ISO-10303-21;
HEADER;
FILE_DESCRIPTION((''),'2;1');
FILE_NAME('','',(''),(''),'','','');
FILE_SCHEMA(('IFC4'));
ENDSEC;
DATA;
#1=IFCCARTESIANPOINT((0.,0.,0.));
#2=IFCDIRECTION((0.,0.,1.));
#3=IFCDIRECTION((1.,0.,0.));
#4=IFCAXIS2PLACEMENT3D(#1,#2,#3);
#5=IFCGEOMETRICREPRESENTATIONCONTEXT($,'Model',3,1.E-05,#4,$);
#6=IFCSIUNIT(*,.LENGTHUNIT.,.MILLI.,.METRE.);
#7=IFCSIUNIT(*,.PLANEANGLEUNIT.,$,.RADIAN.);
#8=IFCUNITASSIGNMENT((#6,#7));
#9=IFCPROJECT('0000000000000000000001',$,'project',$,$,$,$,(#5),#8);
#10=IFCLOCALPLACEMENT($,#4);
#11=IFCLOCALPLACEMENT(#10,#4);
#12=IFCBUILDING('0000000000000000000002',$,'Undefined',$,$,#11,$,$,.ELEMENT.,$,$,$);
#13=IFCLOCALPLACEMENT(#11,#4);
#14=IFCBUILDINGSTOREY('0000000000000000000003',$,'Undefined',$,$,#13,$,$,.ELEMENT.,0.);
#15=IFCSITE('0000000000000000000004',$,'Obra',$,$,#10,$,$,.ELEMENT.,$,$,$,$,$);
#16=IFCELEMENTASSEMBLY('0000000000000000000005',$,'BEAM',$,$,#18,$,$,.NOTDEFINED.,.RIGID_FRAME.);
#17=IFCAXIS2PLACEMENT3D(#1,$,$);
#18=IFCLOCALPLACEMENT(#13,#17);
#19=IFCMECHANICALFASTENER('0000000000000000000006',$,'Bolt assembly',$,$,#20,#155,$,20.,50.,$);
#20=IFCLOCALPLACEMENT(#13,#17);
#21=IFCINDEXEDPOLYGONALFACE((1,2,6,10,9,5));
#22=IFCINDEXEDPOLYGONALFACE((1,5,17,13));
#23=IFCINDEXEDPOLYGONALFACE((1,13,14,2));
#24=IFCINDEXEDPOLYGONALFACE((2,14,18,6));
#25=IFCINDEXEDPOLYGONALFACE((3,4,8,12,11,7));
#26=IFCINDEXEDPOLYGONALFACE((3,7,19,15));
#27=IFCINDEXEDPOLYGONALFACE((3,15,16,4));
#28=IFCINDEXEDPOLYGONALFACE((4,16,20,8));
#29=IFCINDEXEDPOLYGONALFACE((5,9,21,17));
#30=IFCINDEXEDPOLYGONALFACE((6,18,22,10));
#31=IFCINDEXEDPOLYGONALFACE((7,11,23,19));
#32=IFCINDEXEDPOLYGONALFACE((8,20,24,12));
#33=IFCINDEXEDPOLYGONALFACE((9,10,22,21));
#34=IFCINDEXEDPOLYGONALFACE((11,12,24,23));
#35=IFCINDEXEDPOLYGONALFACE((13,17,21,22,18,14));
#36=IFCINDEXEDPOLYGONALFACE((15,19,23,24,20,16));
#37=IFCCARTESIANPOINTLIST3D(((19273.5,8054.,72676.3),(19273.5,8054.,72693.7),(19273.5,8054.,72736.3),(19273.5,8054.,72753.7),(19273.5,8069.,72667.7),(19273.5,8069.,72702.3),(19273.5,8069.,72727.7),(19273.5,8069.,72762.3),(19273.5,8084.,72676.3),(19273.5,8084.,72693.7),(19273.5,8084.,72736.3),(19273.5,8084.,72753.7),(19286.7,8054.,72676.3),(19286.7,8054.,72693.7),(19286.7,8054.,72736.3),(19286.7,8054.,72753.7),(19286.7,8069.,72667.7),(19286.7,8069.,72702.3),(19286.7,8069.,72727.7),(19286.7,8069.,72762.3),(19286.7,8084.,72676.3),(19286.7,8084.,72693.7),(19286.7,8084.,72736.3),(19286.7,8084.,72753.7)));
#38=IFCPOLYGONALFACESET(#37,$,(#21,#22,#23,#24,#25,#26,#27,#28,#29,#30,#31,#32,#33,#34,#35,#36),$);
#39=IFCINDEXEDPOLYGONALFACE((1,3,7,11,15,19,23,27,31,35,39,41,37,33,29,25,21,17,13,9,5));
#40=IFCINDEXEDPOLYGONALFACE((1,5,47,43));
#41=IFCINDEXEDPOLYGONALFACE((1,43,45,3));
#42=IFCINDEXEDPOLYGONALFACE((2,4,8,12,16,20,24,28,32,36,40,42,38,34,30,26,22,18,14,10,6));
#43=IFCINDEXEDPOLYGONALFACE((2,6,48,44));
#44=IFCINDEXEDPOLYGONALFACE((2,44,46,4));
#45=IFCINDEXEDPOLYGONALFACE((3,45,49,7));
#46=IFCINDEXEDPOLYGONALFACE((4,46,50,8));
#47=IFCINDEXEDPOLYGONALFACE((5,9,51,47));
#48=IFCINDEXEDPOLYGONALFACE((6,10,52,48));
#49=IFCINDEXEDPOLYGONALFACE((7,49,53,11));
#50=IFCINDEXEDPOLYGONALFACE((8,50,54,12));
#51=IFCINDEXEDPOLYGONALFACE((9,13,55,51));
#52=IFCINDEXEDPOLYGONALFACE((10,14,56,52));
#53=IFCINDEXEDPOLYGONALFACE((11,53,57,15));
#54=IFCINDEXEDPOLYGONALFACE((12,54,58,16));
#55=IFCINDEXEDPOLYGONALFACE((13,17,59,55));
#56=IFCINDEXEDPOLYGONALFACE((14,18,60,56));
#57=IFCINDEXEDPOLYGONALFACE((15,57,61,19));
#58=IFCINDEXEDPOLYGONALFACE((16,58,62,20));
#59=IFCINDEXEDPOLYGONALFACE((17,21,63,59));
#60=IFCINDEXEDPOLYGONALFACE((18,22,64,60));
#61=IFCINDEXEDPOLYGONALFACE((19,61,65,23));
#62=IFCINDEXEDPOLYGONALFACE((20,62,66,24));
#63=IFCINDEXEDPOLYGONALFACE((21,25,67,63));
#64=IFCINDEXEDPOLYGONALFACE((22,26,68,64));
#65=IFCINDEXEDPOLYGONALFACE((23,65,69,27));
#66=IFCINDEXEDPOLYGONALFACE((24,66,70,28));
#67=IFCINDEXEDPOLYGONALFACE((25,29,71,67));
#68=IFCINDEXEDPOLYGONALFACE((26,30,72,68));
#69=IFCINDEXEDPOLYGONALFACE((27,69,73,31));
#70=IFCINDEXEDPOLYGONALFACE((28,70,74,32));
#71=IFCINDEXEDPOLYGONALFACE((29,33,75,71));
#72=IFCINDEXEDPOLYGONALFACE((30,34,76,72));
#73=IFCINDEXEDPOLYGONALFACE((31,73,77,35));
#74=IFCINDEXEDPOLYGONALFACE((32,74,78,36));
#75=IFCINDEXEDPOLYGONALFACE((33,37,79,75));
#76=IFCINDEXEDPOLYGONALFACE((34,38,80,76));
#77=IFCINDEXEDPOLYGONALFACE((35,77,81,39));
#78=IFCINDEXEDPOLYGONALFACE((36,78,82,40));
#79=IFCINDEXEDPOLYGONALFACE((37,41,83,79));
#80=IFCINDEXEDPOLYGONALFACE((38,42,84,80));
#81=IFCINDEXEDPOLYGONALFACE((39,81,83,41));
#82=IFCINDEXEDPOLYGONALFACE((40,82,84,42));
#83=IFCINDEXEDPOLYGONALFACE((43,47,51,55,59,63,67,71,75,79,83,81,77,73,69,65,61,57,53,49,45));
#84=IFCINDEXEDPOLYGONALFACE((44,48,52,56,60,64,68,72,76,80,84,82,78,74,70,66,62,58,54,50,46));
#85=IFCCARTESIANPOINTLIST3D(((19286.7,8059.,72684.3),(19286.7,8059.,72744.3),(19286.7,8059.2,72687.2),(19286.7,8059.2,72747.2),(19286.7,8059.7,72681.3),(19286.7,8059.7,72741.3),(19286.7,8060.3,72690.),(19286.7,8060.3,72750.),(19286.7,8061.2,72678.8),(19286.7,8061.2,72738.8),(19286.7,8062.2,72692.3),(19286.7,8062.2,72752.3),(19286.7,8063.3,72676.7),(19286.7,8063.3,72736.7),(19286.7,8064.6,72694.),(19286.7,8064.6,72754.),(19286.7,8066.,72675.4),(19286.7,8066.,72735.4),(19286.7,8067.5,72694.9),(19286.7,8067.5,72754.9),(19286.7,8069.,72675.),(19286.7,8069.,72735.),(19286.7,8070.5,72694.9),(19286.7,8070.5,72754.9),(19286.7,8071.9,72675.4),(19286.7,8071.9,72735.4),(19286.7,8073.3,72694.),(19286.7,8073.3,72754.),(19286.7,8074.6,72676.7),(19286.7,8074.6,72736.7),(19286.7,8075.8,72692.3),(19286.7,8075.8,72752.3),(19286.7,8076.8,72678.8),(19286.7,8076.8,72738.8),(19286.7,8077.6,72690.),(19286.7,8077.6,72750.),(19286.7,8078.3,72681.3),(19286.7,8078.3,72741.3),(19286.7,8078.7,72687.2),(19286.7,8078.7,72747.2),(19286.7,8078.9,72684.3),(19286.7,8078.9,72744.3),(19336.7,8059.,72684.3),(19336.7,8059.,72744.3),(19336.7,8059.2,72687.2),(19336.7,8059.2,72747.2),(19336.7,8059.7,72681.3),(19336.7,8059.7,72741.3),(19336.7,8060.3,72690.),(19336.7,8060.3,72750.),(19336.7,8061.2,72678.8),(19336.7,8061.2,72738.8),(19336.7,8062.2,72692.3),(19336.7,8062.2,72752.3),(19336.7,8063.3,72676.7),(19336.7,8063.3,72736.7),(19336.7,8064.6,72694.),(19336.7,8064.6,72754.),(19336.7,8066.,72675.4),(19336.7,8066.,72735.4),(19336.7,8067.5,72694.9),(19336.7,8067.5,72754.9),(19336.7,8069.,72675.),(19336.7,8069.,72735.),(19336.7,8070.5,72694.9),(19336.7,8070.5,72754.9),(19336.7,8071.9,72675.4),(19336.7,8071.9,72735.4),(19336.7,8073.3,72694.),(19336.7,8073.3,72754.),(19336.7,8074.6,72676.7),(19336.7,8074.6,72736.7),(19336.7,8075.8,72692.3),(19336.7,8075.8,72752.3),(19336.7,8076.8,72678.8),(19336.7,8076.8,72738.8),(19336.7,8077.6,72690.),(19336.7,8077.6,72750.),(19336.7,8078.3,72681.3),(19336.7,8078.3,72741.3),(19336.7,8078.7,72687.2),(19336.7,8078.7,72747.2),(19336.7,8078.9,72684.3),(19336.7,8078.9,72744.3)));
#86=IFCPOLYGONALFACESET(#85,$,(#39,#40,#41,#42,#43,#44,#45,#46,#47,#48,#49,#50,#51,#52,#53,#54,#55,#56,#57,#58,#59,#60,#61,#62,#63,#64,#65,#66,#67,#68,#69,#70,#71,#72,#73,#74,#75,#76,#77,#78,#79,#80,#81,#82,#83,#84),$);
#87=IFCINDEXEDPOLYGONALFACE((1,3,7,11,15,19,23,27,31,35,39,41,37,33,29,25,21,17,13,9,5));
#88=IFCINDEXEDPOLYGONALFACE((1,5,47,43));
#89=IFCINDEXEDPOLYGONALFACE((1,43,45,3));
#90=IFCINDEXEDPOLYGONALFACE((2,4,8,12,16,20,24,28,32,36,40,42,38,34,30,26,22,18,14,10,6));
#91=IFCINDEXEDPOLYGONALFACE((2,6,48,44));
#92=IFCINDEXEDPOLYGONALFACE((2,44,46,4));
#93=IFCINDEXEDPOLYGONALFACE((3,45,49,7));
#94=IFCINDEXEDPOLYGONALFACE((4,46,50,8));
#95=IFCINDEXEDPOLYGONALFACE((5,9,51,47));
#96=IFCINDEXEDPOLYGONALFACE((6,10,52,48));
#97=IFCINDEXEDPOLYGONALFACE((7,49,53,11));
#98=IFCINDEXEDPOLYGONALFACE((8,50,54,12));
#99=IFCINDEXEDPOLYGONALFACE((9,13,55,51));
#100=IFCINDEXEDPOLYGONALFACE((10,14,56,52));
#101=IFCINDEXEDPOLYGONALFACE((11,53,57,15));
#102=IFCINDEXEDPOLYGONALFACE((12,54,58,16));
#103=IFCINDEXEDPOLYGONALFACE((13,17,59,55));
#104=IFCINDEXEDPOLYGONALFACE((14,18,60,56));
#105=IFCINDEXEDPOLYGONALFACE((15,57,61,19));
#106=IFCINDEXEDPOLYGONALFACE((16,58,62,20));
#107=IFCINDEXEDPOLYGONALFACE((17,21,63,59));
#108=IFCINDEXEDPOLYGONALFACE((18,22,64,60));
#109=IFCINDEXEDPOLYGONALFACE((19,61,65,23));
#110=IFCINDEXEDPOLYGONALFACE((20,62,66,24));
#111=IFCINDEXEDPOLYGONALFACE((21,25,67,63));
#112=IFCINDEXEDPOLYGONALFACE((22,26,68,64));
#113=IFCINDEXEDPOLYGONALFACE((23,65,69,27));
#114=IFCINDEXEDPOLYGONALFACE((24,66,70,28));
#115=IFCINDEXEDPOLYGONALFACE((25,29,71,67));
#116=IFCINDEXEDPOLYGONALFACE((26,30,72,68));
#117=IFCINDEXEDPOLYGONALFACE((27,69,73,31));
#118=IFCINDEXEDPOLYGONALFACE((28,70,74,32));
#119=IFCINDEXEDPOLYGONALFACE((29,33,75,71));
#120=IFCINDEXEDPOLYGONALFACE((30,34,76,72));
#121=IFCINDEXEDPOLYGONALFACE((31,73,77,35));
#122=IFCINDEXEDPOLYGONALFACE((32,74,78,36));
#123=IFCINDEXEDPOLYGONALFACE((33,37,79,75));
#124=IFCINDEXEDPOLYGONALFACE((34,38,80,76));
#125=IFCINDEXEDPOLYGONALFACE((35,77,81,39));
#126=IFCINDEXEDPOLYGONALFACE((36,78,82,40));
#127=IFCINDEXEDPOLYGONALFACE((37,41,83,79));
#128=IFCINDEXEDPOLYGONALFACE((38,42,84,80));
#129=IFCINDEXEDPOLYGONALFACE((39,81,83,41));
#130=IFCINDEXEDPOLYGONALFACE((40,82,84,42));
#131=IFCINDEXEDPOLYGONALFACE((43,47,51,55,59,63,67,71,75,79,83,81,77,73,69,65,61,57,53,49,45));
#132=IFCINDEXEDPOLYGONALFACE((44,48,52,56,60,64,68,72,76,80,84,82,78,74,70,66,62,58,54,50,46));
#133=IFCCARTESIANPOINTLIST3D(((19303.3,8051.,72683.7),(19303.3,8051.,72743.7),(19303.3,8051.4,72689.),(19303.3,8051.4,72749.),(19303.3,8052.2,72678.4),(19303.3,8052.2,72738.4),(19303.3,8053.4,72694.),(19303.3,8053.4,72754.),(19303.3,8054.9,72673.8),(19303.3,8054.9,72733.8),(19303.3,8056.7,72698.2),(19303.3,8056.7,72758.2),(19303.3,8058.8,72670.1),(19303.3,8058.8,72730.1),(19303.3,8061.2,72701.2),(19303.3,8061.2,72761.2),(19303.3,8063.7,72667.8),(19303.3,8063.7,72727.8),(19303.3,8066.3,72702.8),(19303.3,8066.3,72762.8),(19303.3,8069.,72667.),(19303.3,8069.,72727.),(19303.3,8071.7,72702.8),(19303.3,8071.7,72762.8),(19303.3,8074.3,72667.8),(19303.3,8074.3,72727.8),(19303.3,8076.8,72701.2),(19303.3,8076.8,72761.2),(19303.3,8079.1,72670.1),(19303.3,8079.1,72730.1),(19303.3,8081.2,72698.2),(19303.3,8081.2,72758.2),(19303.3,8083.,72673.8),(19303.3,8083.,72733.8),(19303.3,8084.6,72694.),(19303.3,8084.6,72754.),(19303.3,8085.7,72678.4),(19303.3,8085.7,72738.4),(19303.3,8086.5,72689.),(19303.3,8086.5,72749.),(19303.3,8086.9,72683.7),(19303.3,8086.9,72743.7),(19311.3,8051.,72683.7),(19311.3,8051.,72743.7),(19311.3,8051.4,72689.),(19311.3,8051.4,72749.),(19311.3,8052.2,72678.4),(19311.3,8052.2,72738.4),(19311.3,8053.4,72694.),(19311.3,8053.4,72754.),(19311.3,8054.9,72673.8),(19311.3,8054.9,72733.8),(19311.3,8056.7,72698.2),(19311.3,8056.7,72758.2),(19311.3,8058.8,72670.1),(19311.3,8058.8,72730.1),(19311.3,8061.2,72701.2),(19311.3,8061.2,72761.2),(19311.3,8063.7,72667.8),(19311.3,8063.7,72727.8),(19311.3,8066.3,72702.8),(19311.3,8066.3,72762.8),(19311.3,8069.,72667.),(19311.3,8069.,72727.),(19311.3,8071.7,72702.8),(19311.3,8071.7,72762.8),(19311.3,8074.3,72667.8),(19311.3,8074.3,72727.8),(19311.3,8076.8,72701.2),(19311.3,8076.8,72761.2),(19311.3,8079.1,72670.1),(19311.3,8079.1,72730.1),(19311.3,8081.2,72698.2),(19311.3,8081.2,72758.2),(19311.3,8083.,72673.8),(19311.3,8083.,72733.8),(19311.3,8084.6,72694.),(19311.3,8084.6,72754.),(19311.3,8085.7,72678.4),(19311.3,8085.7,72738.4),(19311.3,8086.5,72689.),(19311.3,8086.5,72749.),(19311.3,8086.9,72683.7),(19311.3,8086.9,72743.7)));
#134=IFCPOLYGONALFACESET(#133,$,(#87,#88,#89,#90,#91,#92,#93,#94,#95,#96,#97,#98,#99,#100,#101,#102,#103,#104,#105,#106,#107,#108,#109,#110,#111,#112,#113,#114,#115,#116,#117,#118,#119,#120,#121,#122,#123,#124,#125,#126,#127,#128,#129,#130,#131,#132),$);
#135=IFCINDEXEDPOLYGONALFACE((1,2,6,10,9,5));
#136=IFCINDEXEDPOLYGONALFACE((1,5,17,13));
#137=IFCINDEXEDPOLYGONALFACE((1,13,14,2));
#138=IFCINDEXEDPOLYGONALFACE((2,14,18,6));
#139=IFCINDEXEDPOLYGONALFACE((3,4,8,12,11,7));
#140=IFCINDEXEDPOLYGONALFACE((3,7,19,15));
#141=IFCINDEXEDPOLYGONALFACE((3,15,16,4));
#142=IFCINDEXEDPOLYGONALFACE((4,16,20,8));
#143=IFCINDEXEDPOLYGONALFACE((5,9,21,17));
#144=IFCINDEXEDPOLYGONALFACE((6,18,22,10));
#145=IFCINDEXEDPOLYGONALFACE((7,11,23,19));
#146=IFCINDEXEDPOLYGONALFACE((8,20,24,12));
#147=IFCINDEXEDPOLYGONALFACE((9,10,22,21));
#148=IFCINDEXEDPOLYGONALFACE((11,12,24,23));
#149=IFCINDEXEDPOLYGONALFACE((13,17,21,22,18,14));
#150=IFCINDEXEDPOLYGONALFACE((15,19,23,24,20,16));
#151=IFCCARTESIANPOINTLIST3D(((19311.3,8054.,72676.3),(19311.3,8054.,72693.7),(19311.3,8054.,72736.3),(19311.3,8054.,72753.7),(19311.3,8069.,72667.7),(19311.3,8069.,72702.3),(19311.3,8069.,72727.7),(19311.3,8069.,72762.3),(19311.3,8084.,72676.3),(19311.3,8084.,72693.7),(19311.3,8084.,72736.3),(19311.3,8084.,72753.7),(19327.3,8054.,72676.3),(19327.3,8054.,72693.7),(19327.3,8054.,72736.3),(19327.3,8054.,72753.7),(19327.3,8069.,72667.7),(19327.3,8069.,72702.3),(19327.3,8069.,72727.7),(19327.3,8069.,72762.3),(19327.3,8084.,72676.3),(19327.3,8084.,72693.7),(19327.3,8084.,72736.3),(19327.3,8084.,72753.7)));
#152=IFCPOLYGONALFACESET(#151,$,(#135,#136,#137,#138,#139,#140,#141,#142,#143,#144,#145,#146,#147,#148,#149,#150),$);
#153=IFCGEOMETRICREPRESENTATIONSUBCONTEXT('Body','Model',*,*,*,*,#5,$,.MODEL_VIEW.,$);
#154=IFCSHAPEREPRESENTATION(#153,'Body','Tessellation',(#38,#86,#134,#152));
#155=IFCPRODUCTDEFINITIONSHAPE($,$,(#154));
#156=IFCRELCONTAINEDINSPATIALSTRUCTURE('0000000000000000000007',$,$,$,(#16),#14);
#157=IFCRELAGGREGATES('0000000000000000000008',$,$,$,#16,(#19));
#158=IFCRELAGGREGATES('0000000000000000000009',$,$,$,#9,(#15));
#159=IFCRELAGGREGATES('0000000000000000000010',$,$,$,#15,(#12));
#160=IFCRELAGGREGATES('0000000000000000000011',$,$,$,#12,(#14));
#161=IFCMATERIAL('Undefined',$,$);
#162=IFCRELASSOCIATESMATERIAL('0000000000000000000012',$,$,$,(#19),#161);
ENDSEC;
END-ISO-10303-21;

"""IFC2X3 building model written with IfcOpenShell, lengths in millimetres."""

from ifc_helpers import new_model, si_unit, frame, origin_with_axes, origin_2d_with_axis, place, context, subcontext, project, spatial, polyline, circle, outline, extrude, source, transform, mapped, material, element, aggregate, save


model = new_model("IFC2X3")

# Units and contexts
model_context = context("Model", 3, precision=1e-05, world=origin_with_axes())
body_context = subcontext(model_context, "Body", "Model", "MODEL_VIEW")
ifc_project = project(units=[si_unit("LENGTHUNIT", "METRE", prefix="MILLI"), si_unit("PLANEANGLEUNIT", "RADIAN")], contexts=[model_context])

# Site, building, storey
site_placement = place(None, origin_with_axes())
site = spatial("IfcSite", under=ifc_project, at=site_placement, Name="Obra", CompositionType="ELEMENT")
building_placement = place(site_placement, origin_with_axes())
building = spatial("IfcBuilding", under=site, at=building_placement, Name="Undefined", CompositionType="ELEMENT")
storey_placement = place(building_placement, origin_with_axes())
storey = spatial("IfcBuildingStorey", under=building, at=storey_placement, Name="Undefined", CompositionType="ELEMENT", Elevation=0.0)

# Shared definitions
ifc_material = material(Name="Undefined")

# Shared definitions
shared_shape_1 = source(origin_with_axes(), body_context, "Body", "SweptSolid", [
    extrude(outline(polyline([(17.3, 0.0), (8.7, 15.0), (-8.7, 15.0), (-17.3, 0.0), (-8.7, -15.0), (8.7, -15.0), (17.3, 0.0)])), frame((0.0, -26.5, 0.0), z_axis=(0.0, 1.0, 0.0), x_axis=(1.0, 0.0, 0.0)), (0.0, 0.0, 1.0), 13.2),
    extrude(circle(Radius=10.0, at=origin_2d_with_axis()), frame((0.0, -13.3, 0.0), z_axis=(0.0, 1.0, 0.0), x_axis=(1.0, 0.0, 0.0)), (0.0, 0.0, 1.0), 50.0),
    extrude(circle(Radius=18.0, at=origin_2d_with_axis()), frame((0.0, 3.3, 0.0), z_axis=(0.0, 1.0, 0.0), x_axis=(1.0, 0.0, 0.0)), (0.0, 0.0, 1.0), 8.0),
    extrude(outline(polyline([(17.3, 0.0), (8.7, 15.0), (-8.7, 15.0), (-17.3, 0.0), (-8.7, -15.0), (8.7, -15.0), (17.3, 0.0)])), frame((0.0, 11.3, 0.0), z_axis=(0.0, 1.0, 0.0), x_axis=(1.0, 0.0, 0.0)), (0.0, 0.0, 1.0), 16.0),
])

# Element assembly, mechanical fastener
assembly_1_placement = place(storey_placement, origin_with_axes())
assembly_1 = element("IfcElementAssembly", 1, at=assembly_1_placement, inside=storey, Name="BEAM", AssemblyPlace="NOTDEFINED", PredefinedType="RIGID_FRAME")
mechanical_fastener_1_placement = place(assembly_1_placement, frame((19300.0, 8109.0, 72850.0), z_axis=(0.0, -1.0, 0.0), x_axis=(0.0, 0.0, -1.0)))
mechanical_fastener_1 = element("IfcMechanicalFastener", 2, at=mechanical_fastener_1_placement, material=ifc_material, Name="Bolt assembly", NominalDiameter=20.0, NominalLength=50.0, context=body_context, shape_type="MappedRepresentation", body=[
    mapped(shared_shape_1, transform((105.0, 0.0, 40.0))),
    mapped(shared_shape_1, transform((165.0, 0.0, 40.0))),
])
aggregate(assembly_1, [mechanical_fastener_1])

save(model, "model.ifc")
